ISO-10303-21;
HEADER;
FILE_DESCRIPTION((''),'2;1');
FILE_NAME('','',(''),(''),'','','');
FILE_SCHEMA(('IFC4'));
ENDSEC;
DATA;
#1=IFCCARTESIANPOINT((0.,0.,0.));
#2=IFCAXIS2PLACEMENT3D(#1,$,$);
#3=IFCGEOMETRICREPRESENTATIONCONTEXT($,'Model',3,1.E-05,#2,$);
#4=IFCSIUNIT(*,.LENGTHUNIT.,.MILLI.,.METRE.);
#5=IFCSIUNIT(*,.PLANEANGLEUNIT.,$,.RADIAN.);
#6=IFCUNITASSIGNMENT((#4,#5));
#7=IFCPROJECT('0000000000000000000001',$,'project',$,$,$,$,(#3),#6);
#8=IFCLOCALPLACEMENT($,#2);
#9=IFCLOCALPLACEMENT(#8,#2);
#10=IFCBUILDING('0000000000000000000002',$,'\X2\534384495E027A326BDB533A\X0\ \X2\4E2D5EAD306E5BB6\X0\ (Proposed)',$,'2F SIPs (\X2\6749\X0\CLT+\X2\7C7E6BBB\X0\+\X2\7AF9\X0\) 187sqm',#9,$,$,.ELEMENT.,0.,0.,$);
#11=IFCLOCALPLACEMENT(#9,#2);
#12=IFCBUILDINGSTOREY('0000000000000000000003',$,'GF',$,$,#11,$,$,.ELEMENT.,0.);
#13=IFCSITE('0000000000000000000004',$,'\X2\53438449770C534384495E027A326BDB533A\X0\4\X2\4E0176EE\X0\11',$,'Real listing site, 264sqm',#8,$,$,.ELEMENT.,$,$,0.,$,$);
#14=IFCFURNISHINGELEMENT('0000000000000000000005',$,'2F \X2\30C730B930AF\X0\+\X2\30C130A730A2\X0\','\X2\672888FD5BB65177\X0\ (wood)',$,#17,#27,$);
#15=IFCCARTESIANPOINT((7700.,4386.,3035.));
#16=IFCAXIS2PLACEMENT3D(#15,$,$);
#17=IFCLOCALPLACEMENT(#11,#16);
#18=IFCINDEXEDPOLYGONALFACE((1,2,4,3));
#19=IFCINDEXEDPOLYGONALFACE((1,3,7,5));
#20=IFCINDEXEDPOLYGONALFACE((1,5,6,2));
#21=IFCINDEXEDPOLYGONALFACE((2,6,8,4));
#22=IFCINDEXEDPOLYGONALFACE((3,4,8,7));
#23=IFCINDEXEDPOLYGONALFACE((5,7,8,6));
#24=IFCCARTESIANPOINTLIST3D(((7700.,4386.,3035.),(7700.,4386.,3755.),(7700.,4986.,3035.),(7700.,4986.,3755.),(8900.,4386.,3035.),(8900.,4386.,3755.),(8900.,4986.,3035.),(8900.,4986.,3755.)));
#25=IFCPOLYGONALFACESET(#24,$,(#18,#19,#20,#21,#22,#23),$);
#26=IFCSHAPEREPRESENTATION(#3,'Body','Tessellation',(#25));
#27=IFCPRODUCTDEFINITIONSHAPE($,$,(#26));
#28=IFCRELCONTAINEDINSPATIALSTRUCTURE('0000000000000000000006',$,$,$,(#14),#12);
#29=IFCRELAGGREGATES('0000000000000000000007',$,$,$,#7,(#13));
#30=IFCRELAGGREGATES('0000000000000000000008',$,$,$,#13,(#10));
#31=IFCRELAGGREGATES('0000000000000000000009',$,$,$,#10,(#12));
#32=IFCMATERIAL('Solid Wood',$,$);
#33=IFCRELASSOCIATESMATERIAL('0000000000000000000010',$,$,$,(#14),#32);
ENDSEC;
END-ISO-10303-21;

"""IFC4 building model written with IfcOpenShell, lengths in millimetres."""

from ifc_helpers import new_model, si_unit, frame, frame_2d, origin, place, context, project, spatial, rectangle, extrude, material, element, save


model = new_model("IFC4")

# Units and contexts
model_context = context("Model", 3, precision=1e-05, world=origin())
ifc_project = project(units=[si_unit("LENGTHUNIT", "METRE", prefix="MILLI"), si_unit("PLANEANGLEUNIT", "RADIAN")], contexts=[model_context])

# Site, building, storey
site_placement = place(None, origin())
site = spatial("IfcSite", under=ifc_project, at=site_placement, Name="千葉県千葉市稲毛区4丁目11", ObjectType="Real listing site, 264sqm", CompositionType="ELEMENT", RefElevation=0.0)
building_placement = place(site_placement, origin())
building = spatial("IfcBuilding", under=site, at=building_placement, Name="千葉市稲毛区 中庭の家 (Proposed)", ObjectType="2F SIPs (杉CLT+籾殻+竹) 187sqm", CompositionType="ELEMENT", ElevationOfRefHeight=0.0, ElevationOfTerrain=0.0)
storey_placement = place(building_placement, origin())
storey = spatial("IfcBuildingStorey", under=building, at=storey_placement, Name="GF", CompositionType="ELEMENT", Elevation=0.0)

# Shared definitions
ifc_material_1 = material(Name="Solid Wood")

# Furnishing element
furnishing_1_placement = place(storey_placement, frame((7700.0, 4386.0, 3035.0)))
element("IfcFurnishingElement", 1, at=furnishing_1_placement, inside=storey, material=ifc_material_1, Name="2F デスク+チェア", Description="木製家具 (wood)", context=model_context, shape_type="SweptSolid", body=[
    extrude(rectangle(XDim=1200.0, YDim=600.0, at=frame_2d((600.0, 300.0))), frame((7700.0, 4386.0, 3035.0)), (0.0, 0.0, 1.0), 720.0),
])

save(model, "model.ifc")
